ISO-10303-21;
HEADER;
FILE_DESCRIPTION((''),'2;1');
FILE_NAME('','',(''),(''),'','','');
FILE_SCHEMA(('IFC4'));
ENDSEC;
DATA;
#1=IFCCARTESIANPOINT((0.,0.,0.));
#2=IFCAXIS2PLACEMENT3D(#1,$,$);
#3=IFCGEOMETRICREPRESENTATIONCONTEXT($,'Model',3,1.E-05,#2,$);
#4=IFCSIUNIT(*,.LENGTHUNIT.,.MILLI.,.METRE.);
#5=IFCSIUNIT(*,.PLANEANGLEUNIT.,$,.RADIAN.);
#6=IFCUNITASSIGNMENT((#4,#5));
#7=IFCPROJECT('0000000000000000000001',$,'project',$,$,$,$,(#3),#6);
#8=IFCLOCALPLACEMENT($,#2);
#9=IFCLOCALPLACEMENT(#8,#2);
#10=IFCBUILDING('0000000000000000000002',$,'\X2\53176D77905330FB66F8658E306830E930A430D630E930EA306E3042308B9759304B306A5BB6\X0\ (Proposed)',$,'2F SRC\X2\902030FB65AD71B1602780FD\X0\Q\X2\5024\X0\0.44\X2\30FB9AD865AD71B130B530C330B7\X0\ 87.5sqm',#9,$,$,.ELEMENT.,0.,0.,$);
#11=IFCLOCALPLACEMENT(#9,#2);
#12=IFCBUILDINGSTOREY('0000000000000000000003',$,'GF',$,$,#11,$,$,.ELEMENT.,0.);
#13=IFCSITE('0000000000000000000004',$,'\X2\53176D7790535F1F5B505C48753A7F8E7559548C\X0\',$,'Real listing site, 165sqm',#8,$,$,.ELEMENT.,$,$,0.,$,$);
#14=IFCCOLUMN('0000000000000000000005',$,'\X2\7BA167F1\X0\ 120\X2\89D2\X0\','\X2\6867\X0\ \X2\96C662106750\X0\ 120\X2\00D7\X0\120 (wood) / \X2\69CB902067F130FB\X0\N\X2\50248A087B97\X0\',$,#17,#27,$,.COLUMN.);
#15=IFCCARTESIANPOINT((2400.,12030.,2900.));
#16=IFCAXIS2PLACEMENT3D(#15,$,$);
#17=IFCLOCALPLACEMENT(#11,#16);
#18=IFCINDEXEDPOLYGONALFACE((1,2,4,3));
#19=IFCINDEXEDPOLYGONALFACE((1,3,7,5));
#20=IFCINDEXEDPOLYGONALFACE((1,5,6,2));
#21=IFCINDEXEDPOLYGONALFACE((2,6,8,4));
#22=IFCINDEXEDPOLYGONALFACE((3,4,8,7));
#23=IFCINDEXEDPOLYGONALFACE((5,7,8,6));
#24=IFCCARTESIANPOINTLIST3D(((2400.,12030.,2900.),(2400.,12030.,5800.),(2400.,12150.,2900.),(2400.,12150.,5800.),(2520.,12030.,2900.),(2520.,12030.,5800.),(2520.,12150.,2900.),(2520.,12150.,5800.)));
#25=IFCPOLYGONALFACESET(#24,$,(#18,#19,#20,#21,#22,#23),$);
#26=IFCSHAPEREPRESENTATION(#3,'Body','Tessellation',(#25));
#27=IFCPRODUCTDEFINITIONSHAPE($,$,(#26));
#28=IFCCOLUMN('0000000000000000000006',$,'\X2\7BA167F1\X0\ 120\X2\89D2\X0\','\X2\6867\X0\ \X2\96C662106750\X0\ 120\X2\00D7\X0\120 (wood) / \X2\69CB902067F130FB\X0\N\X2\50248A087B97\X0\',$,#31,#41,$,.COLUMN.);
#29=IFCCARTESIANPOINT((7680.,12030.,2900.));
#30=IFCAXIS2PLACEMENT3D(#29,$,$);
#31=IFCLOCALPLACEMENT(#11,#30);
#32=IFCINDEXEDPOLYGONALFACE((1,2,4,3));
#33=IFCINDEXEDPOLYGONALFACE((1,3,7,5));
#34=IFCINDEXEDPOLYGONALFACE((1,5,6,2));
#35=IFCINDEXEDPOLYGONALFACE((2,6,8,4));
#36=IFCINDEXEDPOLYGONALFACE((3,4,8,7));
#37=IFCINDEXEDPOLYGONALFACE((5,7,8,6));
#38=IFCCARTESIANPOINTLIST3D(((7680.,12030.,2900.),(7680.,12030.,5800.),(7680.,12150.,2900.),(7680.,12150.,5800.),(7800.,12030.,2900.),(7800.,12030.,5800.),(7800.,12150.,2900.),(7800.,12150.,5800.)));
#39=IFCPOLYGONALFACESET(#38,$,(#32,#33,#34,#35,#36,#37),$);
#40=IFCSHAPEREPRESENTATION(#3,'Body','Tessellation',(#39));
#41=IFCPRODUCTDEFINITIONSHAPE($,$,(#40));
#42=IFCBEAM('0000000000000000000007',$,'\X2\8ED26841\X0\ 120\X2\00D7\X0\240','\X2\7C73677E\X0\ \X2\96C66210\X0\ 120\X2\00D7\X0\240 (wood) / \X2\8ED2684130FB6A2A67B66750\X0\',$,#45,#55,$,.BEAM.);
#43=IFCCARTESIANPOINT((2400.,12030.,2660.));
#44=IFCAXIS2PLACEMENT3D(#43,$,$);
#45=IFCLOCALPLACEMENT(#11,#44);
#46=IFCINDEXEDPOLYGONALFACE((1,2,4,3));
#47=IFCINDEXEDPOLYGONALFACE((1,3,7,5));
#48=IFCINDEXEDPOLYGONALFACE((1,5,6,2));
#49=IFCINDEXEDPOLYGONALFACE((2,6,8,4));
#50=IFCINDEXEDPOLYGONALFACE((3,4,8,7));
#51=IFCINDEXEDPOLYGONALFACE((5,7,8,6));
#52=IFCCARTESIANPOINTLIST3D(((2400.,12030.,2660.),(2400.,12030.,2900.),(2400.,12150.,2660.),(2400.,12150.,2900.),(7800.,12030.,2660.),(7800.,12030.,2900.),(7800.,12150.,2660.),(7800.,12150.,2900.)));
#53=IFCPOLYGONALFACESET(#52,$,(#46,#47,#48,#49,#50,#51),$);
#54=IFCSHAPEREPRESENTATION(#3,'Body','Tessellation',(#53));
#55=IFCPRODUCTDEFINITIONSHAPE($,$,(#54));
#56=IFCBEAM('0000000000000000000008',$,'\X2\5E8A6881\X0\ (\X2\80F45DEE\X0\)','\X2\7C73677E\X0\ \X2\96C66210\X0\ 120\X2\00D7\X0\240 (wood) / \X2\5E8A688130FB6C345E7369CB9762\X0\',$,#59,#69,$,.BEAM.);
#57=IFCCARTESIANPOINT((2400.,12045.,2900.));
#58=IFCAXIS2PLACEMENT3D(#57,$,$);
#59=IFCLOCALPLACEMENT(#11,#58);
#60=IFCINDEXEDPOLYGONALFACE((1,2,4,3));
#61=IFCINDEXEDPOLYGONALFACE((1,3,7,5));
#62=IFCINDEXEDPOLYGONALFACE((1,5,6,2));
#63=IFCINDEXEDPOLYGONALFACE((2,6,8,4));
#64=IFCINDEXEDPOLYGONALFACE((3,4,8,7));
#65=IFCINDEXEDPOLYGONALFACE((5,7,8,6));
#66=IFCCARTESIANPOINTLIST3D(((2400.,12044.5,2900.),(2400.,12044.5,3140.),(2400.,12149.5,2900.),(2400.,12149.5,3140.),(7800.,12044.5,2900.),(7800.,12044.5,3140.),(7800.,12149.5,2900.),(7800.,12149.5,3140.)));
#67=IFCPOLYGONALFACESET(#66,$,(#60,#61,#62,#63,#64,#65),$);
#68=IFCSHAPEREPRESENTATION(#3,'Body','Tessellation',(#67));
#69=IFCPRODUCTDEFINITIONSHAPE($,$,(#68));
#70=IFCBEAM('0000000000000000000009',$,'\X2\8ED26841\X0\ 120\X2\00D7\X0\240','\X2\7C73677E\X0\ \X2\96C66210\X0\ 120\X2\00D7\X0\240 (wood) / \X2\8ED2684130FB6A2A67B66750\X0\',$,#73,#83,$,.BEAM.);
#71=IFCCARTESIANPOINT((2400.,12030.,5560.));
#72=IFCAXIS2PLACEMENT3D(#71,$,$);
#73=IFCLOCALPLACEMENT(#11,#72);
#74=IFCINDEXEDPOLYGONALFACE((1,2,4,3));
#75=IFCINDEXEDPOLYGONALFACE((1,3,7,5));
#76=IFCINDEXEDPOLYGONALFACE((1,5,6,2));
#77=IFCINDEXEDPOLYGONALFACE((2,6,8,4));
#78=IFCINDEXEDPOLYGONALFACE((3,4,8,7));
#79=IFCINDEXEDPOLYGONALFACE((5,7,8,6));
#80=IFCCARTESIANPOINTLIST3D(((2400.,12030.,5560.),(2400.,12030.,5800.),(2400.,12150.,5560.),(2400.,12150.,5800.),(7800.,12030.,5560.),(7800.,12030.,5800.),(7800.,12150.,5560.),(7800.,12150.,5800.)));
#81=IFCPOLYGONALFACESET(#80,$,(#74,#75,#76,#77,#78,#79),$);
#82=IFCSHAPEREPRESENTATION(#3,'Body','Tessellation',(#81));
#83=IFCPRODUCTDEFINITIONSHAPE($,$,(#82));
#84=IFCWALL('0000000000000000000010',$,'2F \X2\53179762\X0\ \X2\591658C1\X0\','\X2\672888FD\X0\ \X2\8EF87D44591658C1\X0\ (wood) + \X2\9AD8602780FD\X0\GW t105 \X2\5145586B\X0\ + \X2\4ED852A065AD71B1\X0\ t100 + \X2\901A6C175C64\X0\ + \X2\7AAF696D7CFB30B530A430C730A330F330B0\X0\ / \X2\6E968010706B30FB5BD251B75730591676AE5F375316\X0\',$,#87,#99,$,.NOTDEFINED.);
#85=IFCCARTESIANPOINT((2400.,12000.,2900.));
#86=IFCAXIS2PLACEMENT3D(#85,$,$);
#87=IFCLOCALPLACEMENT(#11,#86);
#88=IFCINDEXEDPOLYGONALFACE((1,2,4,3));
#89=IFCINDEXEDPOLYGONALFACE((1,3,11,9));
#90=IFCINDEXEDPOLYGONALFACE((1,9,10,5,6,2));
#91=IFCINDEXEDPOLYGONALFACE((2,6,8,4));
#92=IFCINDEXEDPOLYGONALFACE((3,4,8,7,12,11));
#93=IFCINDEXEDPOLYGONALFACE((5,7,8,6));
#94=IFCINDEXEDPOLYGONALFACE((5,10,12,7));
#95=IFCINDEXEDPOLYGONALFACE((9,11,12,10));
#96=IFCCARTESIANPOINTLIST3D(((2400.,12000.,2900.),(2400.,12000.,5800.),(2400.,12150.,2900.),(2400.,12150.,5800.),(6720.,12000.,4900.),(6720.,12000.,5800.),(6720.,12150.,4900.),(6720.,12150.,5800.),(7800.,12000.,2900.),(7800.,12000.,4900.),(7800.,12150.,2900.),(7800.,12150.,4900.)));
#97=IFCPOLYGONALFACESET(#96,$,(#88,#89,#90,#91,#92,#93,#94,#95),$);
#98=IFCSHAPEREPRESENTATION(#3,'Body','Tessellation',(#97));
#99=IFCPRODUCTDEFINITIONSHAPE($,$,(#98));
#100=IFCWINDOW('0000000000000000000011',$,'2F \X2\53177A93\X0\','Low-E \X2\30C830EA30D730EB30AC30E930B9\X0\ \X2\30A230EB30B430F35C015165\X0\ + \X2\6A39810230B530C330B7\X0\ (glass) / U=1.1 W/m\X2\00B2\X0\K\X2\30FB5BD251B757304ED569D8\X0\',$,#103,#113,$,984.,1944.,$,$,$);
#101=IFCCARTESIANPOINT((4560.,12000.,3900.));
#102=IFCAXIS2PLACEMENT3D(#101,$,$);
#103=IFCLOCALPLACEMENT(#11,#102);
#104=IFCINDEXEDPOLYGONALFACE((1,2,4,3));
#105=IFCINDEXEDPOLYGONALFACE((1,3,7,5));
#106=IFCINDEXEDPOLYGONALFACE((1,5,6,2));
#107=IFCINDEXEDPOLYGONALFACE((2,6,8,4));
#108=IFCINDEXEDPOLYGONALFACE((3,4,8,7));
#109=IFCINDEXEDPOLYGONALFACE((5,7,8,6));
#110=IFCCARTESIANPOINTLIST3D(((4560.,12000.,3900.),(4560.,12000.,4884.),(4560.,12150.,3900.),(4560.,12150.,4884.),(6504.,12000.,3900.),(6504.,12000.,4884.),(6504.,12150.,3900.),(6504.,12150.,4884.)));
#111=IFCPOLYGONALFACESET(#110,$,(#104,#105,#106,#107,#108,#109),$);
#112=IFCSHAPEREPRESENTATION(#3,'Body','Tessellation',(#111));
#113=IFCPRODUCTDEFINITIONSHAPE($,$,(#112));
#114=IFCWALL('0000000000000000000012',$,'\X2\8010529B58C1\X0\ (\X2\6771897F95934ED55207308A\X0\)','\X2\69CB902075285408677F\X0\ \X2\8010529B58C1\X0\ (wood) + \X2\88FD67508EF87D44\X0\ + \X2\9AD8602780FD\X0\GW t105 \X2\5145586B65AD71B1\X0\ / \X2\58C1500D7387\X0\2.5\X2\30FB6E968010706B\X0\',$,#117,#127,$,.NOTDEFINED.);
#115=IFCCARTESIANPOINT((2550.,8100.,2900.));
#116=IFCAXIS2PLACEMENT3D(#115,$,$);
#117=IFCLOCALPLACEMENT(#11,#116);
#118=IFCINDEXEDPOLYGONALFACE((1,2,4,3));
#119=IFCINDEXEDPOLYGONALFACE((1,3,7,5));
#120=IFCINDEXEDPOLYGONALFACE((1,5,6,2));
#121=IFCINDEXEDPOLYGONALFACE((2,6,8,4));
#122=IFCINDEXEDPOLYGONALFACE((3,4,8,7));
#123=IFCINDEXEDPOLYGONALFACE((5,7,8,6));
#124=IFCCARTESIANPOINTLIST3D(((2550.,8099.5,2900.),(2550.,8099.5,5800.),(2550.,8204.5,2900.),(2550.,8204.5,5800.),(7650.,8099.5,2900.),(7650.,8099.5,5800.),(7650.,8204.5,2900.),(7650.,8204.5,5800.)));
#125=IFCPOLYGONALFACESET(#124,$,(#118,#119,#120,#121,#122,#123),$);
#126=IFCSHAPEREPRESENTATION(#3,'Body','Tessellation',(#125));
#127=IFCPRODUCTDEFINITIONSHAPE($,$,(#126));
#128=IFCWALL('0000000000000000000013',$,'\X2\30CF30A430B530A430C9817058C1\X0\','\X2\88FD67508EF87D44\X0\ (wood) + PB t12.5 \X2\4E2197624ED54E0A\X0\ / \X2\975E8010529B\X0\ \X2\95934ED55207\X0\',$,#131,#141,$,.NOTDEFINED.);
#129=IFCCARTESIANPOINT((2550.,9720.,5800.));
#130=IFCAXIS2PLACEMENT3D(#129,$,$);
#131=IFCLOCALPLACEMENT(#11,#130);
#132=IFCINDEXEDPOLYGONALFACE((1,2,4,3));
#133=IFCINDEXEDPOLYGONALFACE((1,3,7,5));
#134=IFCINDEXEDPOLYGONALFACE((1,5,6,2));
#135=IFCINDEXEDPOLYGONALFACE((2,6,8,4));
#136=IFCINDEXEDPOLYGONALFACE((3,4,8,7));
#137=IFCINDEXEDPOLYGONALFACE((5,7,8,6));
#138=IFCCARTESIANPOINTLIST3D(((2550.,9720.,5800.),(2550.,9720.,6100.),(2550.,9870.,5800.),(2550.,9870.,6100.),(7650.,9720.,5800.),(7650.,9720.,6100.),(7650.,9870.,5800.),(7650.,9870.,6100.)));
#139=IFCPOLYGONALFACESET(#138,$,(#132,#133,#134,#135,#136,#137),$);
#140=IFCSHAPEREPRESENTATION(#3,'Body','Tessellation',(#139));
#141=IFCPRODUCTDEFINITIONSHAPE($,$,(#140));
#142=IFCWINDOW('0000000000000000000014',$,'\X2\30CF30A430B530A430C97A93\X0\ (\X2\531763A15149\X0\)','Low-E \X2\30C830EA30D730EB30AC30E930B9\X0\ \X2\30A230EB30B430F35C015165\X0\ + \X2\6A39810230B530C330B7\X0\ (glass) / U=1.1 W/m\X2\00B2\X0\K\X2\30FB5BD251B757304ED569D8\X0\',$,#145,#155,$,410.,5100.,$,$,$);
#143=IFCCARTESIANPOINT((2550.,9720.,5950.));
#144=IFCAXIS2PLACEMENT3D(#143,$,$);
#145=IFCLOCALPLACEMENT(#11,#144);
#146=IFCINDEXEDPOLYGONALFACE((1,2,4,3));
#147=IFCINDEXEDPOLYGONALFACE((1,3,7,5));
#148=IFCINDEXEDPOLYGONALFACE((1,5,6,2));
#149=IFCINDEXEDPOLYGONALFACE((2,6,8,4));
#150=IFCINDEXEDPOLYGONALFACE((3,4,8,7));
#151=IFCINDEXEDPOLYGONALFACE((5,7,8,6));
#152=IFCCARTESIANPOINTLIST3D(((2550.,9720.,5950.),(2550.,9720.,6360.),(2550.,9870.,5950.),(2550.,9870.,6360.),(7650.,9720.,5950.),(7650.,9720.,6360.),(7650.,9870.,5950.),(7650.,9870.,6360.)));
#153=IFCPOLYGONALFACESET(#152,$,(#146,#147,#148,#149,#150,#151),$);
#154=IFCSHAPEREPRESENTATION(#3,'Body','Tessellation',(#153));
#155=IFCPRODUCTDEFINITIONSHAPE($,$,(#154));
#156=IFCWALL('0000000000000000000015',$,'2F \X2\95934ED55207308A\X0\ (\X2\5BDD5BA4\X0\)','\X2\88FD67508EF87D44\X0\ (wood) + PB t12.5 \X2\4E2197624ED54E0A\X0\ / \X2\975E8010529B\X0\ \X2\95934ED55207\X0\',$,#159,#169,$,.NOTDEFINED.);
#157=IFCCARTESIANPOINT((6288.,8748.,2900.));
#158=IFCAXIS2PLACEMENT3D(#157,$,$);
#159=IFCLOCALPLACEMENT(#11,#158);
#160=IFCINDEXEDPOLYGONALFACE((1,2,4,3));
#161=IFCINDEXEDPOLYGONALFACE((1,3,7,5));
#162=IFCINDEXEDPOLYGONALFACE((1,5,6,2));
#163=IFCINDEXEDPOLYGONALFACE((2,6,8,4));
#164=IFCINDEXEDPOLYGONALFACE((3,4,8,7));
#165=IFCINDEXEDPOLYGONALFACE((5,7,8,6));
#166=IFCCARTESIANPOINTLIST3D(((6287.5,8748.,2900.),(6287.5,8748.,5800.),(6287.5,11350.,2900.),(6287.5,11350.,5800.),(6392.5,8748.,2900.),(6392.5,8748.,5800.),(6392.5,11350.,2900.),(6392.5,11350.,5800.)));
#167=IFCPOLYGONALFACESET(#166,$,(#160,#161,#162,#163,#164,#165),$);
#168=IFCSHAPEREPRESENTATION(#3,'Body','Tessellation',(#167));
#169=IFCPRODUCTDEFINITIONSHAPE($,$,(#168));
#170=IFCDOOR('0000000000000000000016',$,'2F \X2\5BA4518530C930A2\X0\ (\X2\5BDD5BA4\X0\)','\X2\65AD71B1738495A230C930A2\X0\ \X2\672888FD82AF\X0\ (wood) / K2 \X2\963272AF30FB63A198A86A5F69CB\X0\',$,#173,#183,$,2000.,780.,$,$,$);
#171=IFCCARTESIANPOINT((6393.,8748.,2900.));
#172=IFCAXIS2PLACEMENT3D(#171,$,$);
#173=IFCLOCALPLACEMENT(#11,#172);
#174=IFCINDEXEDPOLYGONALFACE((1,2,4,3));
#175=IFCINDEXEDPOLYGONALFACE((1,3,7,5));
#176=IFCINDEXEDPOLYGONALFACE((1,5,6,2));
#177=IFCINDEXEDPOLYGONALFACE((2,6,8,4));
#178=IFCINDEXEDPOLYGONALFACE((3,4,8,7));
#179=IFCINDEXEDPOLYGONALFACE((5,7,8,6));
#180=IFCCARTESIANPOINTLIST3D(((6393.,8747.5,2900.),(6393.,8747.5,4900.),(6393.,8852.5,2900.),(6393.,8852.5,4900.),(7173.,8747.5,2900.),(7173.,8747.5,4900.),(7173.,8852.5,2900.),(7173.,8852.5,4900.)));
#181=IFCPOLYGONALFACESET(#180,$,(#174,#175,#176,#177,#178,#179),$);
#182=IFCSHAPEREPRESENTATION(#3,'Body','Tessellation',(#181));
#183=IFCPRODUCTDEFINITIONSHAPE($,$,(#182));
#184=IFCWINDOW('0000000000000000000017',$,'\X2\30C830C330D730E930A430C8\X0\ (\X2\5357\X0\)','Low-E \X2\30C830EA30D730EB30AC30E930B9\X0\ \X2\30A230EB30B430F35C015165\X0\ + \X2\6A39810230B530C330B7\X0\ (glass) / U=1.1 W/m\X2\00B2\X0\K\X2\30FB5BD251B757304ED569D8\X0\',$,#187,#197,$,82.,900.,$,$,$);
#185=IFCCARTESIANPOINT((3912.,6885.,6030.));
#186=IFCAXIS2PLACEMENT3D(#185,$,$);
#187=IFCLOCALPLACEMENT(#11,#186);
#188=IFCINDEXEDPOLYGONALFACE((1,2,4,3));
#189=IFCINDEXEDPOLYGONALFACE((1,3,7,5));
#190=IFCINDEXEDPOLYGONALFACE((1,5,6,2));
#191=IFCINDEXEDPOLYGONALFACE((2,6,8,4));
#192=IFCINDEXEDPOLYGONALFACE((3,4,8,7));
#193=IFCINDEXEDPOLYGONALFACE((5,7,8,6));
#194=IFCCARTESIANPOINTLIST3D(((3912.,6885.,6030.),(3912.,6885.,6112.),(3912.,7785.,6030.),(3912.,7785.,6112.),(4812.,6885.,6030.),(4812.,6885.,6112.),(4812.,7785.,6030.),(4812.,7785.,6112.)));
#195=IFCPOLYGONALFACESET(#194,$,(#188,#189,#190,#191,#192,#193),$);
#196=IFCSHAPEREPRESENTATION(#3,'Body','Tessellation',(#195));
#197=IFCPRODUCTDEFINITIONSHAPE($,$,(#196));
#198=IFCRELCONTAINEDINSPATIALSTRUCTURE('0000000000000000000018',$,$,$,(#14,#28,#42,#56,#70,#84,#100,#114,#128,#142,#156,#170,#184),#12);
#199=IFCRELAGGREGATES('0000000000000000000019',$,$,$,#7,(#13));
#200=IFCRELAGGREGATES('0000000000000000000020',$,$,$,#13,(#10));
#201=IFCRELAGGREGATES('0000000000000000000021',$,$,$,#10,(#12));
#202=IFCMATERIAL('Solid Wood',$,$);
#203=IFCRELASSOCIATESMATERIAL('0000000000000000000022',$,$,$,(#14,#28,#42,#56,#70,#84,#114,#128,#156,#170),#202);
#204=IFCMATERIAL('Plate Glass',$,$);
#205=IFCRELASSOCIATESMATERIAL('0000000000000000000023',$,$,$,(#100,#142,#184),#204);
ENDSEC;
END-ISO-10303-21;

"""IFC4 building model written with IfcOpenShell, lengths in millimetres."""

from ifc_helpers import new_model, si_unit, frame, frame_2d, origin, place, context, project, spatial, rectangle, extrude, material, element, fill, save


model = new_model("IFC4")

# Units and contexts
model_context = context("Model", 3, precision=1e-05, world=origin())
ifc_project = project(units=[si_unit("LENGTHUNIT", "METRE", prefix="MILLI"), si_unit("PLANEANGLEUNIT", "RADIAN")], contexts=[model_context])

# Site, building, storey
site_placement = place(None, origin())
site = spatial("IfcSite", under=ifc_project, at=site_placement, Name="北海道弟子屈町美留和", ObjectType="Real listing site, 165sqm", CompositionType="ELEMENT", RefElevation=0.0)
building_placement = place(site_placement, origin())
building = spatial("IfcBuilding", under=site, at=building_placement, Name="北海道・書斎とライブラリのある静かな家 (Proposed)", ObjectType="2F SRC造・断熱性能Q値0.44・高断熱サッシ 87.5sqm", CompositionType="ELEMENT", ElevationOfRefHeight=0.0, ElevationOfTerrain=0.0)
storey_placement = place(building_placement, origin())
storey = spatial("IfcBuildingStorey", under=building, at=storey_placement, Name="GF", CompositionType="ELEMENT", Elevation=0.0)

# Columns
ifc_material_1 = material(Name="Solid Wood")
column_1_placement = place(storey_placement, frame((2400.0, 12030.0, 2900.0)))
element("IfcColumn", 1, at=column_1_placement, inside=storey, material=ifc_material_1, Name="管柱 120角", Description="桧 集成材 120×120 (wood) / 構造柱・N値計算", PredefinedType="COLUMN", context=model_context, shape_type="SweptSolid", body=[
    extrude(rectangle(XDim=120.0, YDim=120.0, at=frame_2d((60.0, 60.0))), frame((2400.0, 12030.0, 2900.0)), (0.0, 0.0, 1.0), 2900.0),
])
column_2_placement = place(storey_placement, frame((7680.0, 12030.0, 2900.0)))
element("IfcColumn", 2, at=column_2_placement, inside=storey, material=ifc_material_1, Name="管柱 120角", Description="桧 集成材 120×120 (wood) / 構造柱・N値計算", PredefinedType="COLUMN", context=model_context, shape_type="SweptSolid", body=[
    extrude(rectangle(XDim=120.0, YDim=120.0, at=frame_2d((60.0, 60.0))), frame((7680.0, 12030.0, 2900.0)), (0.0, 0.0, 1.0), 2900.0),
])

# Beams
beam_1_placement = place(storey_placement, frame((2400.0, 12030.0, 2660.0)))
element("IfcBeam", 3, at=beam_1_placement, inside=storey, material=ifc_material_1, Name="軒桁 120×240", Description="米松 集成 120×240 (wood) / 軒桁・横架材", PredefinedType="BEAM", context=model_context, shape_type="SweptSolid", body=[
    extrude(rectangle(XDim=5400.0, YDim=120.0, at=frame_2d((2700.0, 60.0))), frame((2400.0, 12030.0, 2660.0)), (0.0, 0.0, 1.0), 240.0),
])
beam_2_placement = place(storey_placement, frame((2400.0, 12045.0, 2900.0)))
element("IfcBeam", 4, at=beam_2_placement, inside=storey, material=ifc_material_1, Name="床梁 (胴差)", Description="米松 集成 120×240 (wood) / 床梁・水平構面", PredefinedType="BEAM", context=model_context, shape_type="SweptSolid", body=[
    extrude(rectangle(XDim=5400.0, YDim=105.0, at=frame_2d((2700.0, 52.0))), frame((2400.0, 12045.0, 2900.0)), (0.0, 0.0, 1.0), 240.0),
])
beam_3_placement = place(storey_placement, frame((2400.0, 12030.0, 5560.0)))
element("IfcBeam", 5, at=beam_3_placement, inside=storey, material=ifc_material_1, Name="軒桁 120×240", Description="米松 集成 120×240 (wood) / 軒桁・横架材", PredefinedType="BEAM", context=model_context, shape_type="SweptSolid", body=[
    extrude(rectangle(XDim=5400.0, YDim=120.0, at=frame_2d((2700.0, 60.0))), frame((2400.0, 12030.0, 5560.0)), (0.0, 0.0, 1.0), 240.0),
])

# Wall, opening, window
wall_1_placement = place(storey_placement, frame((2400.0, 12000.0, 2900.0)))
wall_1 = element("IfcWall", 6, at=wall_1_placement, inside=storey, material=ifc_material_1, Name="2F 北面 外壁", Description="木製 軸組外壁 (wood) + 高性能GW t105 充填 + 付加断熱 t100 + 通気層 + 窯業系サイディング / 準耐火・寒冷地外皮強化", PredefinedType="NOTDEFINED", context=model_context, shape_type="SweptSolid", body=[
    extrude(rectangle(XDim=5400.0, YDim=150.0, at=frame_2d((2700.0, 75.0))), frame((2400.0, 12000.0, 2900.0)), (0.0, 0.0, 1.0), 2900.0),
])
opening_1_placement = place(storey_placement, frame((4560.0, 12000.0, 3900.0)))
opening_1 = element("IfcOpeningElement", 7, at=opening_1_placement, cuts=wall_1, PredefinedType="NOTDEFINED", context=model_context, shape_type="SweptSolid", body=[
    extrude(rectangle(XDim=1944.0, YDim=150.0, at=frame_2d((972.0, 75.0))), frame((4560.0, 12000.0, 3900.0)), (0.0, 0.0, 1.0), 984.0),
])
ifc_material_2 = material(Name="Plate Glass")
window_1_placement = place(storey_placement, frame((4560.0, 12000.0, 3900.0)))
window_1 = element("IfcWindow", 8, at=window_1_placement, inside=storey, material=ifc_material_2, Name="2F 北窓", Description="Low-E トリプルガラス アルゴン封入 + 樹脂サッシ (glass) / U=1.1 W/m²K・寒冷地仕様", OverallHeight=984.0, OverallWidth=1944.0, context=model_context, shape_type="SweptSolid", body=[
    extrude(rectangle(XDim=1944.0, YDim=150.0, at=frame_2d((972.0, 75.0))), frame((4560.0, 12000.0, 3900.0)), (0.0, 0.0, 1.0), 984.0),
])
fill(opening_1, window_1)

# Wall
wall_2_placement = place(storey_placement, frame((2550.0, 8100.0, 2900.0)))
element("IfcWall", 9, at=wall_2_placement, inside=storey, material=ifc_material_1, Name="耐力壁 (東西間仕切り)", Description="構造用合板 耐力壁 (wood) + 製材軸組 + 高性能GW t105 充填断熱 / 壁倍率2.5・準耐火", PredefinedType="NOTDEFINED", context=model_context, shape_type="SweptSolid", body=[
    extrude(rectangle(XDim=5100.0, YDim=105.0, at=frame_2d((2550.0, 52.0))), frame((2550.0, 8100.0, 2900.0)), (0.0, 0.0, 1.0), 2900.0),
])

# Wall, opening, window
wall_3_placement = place(storey_placement, frame((2550.0, 9720.0, 5800.0)))
wall_3 = element("IfcWall", 10, at=wall_3_placement, inside=storey, material=ifc_material_1, Name="ハイサイド腰壁", Description="製材軸組 (wood) + PB t12.5 両面仕上 / 非耐力 間仕切", PredefinedType="NOTDEFINED", context=model_context, shape_type="SweptSolid", body=[
    extrude(rectangle(XDim=5100.0, YDim=150.0, at=frame_2d((2550.0, 75.0))), frame((2550.0, 9720.0, 5800.0)), (0.0, 0.0, 1.0), 700.0),
])
opening_2_placement = place(storey_placement, frame((2550.0, 9720.0, 5950.0)))
opening_2 = element("IfcOpeningElement", 11, at=opening_2_placement, cuts=wall_3, PredefinedType="NOTDEFINED", context=model_context, shape_type="SweptSolid", body=[
    extrude(rectangle(XDim=5100.0, YDim=150.0, at=frame_2d((2550.0, 75.0))), frame((2550.0, 9720.0, 5950.0)), (0.0, 0.0, 1.0), 410.0),
])
window_2_placement = place(storey_placement, frame((2550.0, 9720.0, 5950.0)))
window_2 = element("IfcWindow", 12, at=window_2_placement, inside=storey, material=ifc_material_2, Name="ハイサイド窓 (北採光)", Description="Low-E トリプルガラス アルゴン封入 + 樹脂サッシ (glass) / U=1.1 W/m²K・寒冷地仕様", OverallHeight=410.0, OverallWidth=5100.0, context=model_context, shape_type="SweptSolid", body=[
    extrude(rectangle(XDim=5100.0, YDim=150.0, at=frame_2d((2550.0, 75.0))), frame((2550.0, 9720.0, 5950.0)), (0.0, 0.0, 1.0), 410.0),
])
fill(opening_2, window_2)

# Wall
wall_4_placement = place(storey_placement, frame((6288.0, 8748.0, 2900.0)))
element("IfcWall", 13, at=wall_4_placement, inside=storey, material=ifc_material_1, Name="2F 間仕切り (寝室)", Description="製材軸組 (wood) + PB t12.5 両面仕上 / 非耐力 間仕切", PredefinedType="NOTDEFINED", context=model_context, shape_type="SweptSolid", body=[
    extrude(rectangle(XDim=105.0, YDim=2602.0, at=frame_2d((52.0, 1301.0))), frame((6288.0, 8748.0, 2900.0)), (0.0, 0.0, 1.0), 2900.0),
])

# Door
door_placement = place(storey_placement, frame((6393.0, 8748.0, 2900.0)))
element("IfcDoor", 14, at=door_placement, inside=storey, material=ifc_material_1, Name="2F 室内ドア (寝室)", Description="断熱玄関ドア 木製芯 (wood) / K2 防犯・採風機構", OverallHeight=2000.0, OverallWidth=780.0, context=model_context, shape_type="SweptSolid", body=[
    extrude(rectangle(XDim=780.0, YDim=105.0, at=frame_2d((390.0, 52.0))), frame((6393.0, 8748.0, 2900.0)), (0.0, 0.0, 1.0), 2000.0),
])

# Window
window_3_placement = place(storey_placement, frame((3912.0, 6885.0, 6030.0)))
element("IfcWindow", 15, at=window_3_placement, inside=storey, material=ifc_material_2, Name="トップライト (南)", Description="Low-E トリプルガラス アルゴン封入 + 樹脂サッシ (glass) / U=1.1 W/m²K・寒冷地仕様", OverallHeight=82.0, OverallWidth=900.0, context=model_context, shape_type="SweptSolid", body=[
    extrude(rectangle(XDim=900.0, YDim=900.0, at=frame_2d((450.0, 450.0))), frame((3912.0, 6885.0, 6030.0)), (0.0, 0.0, 1.0), 82.0),
])

save(model, "model.ifc")
